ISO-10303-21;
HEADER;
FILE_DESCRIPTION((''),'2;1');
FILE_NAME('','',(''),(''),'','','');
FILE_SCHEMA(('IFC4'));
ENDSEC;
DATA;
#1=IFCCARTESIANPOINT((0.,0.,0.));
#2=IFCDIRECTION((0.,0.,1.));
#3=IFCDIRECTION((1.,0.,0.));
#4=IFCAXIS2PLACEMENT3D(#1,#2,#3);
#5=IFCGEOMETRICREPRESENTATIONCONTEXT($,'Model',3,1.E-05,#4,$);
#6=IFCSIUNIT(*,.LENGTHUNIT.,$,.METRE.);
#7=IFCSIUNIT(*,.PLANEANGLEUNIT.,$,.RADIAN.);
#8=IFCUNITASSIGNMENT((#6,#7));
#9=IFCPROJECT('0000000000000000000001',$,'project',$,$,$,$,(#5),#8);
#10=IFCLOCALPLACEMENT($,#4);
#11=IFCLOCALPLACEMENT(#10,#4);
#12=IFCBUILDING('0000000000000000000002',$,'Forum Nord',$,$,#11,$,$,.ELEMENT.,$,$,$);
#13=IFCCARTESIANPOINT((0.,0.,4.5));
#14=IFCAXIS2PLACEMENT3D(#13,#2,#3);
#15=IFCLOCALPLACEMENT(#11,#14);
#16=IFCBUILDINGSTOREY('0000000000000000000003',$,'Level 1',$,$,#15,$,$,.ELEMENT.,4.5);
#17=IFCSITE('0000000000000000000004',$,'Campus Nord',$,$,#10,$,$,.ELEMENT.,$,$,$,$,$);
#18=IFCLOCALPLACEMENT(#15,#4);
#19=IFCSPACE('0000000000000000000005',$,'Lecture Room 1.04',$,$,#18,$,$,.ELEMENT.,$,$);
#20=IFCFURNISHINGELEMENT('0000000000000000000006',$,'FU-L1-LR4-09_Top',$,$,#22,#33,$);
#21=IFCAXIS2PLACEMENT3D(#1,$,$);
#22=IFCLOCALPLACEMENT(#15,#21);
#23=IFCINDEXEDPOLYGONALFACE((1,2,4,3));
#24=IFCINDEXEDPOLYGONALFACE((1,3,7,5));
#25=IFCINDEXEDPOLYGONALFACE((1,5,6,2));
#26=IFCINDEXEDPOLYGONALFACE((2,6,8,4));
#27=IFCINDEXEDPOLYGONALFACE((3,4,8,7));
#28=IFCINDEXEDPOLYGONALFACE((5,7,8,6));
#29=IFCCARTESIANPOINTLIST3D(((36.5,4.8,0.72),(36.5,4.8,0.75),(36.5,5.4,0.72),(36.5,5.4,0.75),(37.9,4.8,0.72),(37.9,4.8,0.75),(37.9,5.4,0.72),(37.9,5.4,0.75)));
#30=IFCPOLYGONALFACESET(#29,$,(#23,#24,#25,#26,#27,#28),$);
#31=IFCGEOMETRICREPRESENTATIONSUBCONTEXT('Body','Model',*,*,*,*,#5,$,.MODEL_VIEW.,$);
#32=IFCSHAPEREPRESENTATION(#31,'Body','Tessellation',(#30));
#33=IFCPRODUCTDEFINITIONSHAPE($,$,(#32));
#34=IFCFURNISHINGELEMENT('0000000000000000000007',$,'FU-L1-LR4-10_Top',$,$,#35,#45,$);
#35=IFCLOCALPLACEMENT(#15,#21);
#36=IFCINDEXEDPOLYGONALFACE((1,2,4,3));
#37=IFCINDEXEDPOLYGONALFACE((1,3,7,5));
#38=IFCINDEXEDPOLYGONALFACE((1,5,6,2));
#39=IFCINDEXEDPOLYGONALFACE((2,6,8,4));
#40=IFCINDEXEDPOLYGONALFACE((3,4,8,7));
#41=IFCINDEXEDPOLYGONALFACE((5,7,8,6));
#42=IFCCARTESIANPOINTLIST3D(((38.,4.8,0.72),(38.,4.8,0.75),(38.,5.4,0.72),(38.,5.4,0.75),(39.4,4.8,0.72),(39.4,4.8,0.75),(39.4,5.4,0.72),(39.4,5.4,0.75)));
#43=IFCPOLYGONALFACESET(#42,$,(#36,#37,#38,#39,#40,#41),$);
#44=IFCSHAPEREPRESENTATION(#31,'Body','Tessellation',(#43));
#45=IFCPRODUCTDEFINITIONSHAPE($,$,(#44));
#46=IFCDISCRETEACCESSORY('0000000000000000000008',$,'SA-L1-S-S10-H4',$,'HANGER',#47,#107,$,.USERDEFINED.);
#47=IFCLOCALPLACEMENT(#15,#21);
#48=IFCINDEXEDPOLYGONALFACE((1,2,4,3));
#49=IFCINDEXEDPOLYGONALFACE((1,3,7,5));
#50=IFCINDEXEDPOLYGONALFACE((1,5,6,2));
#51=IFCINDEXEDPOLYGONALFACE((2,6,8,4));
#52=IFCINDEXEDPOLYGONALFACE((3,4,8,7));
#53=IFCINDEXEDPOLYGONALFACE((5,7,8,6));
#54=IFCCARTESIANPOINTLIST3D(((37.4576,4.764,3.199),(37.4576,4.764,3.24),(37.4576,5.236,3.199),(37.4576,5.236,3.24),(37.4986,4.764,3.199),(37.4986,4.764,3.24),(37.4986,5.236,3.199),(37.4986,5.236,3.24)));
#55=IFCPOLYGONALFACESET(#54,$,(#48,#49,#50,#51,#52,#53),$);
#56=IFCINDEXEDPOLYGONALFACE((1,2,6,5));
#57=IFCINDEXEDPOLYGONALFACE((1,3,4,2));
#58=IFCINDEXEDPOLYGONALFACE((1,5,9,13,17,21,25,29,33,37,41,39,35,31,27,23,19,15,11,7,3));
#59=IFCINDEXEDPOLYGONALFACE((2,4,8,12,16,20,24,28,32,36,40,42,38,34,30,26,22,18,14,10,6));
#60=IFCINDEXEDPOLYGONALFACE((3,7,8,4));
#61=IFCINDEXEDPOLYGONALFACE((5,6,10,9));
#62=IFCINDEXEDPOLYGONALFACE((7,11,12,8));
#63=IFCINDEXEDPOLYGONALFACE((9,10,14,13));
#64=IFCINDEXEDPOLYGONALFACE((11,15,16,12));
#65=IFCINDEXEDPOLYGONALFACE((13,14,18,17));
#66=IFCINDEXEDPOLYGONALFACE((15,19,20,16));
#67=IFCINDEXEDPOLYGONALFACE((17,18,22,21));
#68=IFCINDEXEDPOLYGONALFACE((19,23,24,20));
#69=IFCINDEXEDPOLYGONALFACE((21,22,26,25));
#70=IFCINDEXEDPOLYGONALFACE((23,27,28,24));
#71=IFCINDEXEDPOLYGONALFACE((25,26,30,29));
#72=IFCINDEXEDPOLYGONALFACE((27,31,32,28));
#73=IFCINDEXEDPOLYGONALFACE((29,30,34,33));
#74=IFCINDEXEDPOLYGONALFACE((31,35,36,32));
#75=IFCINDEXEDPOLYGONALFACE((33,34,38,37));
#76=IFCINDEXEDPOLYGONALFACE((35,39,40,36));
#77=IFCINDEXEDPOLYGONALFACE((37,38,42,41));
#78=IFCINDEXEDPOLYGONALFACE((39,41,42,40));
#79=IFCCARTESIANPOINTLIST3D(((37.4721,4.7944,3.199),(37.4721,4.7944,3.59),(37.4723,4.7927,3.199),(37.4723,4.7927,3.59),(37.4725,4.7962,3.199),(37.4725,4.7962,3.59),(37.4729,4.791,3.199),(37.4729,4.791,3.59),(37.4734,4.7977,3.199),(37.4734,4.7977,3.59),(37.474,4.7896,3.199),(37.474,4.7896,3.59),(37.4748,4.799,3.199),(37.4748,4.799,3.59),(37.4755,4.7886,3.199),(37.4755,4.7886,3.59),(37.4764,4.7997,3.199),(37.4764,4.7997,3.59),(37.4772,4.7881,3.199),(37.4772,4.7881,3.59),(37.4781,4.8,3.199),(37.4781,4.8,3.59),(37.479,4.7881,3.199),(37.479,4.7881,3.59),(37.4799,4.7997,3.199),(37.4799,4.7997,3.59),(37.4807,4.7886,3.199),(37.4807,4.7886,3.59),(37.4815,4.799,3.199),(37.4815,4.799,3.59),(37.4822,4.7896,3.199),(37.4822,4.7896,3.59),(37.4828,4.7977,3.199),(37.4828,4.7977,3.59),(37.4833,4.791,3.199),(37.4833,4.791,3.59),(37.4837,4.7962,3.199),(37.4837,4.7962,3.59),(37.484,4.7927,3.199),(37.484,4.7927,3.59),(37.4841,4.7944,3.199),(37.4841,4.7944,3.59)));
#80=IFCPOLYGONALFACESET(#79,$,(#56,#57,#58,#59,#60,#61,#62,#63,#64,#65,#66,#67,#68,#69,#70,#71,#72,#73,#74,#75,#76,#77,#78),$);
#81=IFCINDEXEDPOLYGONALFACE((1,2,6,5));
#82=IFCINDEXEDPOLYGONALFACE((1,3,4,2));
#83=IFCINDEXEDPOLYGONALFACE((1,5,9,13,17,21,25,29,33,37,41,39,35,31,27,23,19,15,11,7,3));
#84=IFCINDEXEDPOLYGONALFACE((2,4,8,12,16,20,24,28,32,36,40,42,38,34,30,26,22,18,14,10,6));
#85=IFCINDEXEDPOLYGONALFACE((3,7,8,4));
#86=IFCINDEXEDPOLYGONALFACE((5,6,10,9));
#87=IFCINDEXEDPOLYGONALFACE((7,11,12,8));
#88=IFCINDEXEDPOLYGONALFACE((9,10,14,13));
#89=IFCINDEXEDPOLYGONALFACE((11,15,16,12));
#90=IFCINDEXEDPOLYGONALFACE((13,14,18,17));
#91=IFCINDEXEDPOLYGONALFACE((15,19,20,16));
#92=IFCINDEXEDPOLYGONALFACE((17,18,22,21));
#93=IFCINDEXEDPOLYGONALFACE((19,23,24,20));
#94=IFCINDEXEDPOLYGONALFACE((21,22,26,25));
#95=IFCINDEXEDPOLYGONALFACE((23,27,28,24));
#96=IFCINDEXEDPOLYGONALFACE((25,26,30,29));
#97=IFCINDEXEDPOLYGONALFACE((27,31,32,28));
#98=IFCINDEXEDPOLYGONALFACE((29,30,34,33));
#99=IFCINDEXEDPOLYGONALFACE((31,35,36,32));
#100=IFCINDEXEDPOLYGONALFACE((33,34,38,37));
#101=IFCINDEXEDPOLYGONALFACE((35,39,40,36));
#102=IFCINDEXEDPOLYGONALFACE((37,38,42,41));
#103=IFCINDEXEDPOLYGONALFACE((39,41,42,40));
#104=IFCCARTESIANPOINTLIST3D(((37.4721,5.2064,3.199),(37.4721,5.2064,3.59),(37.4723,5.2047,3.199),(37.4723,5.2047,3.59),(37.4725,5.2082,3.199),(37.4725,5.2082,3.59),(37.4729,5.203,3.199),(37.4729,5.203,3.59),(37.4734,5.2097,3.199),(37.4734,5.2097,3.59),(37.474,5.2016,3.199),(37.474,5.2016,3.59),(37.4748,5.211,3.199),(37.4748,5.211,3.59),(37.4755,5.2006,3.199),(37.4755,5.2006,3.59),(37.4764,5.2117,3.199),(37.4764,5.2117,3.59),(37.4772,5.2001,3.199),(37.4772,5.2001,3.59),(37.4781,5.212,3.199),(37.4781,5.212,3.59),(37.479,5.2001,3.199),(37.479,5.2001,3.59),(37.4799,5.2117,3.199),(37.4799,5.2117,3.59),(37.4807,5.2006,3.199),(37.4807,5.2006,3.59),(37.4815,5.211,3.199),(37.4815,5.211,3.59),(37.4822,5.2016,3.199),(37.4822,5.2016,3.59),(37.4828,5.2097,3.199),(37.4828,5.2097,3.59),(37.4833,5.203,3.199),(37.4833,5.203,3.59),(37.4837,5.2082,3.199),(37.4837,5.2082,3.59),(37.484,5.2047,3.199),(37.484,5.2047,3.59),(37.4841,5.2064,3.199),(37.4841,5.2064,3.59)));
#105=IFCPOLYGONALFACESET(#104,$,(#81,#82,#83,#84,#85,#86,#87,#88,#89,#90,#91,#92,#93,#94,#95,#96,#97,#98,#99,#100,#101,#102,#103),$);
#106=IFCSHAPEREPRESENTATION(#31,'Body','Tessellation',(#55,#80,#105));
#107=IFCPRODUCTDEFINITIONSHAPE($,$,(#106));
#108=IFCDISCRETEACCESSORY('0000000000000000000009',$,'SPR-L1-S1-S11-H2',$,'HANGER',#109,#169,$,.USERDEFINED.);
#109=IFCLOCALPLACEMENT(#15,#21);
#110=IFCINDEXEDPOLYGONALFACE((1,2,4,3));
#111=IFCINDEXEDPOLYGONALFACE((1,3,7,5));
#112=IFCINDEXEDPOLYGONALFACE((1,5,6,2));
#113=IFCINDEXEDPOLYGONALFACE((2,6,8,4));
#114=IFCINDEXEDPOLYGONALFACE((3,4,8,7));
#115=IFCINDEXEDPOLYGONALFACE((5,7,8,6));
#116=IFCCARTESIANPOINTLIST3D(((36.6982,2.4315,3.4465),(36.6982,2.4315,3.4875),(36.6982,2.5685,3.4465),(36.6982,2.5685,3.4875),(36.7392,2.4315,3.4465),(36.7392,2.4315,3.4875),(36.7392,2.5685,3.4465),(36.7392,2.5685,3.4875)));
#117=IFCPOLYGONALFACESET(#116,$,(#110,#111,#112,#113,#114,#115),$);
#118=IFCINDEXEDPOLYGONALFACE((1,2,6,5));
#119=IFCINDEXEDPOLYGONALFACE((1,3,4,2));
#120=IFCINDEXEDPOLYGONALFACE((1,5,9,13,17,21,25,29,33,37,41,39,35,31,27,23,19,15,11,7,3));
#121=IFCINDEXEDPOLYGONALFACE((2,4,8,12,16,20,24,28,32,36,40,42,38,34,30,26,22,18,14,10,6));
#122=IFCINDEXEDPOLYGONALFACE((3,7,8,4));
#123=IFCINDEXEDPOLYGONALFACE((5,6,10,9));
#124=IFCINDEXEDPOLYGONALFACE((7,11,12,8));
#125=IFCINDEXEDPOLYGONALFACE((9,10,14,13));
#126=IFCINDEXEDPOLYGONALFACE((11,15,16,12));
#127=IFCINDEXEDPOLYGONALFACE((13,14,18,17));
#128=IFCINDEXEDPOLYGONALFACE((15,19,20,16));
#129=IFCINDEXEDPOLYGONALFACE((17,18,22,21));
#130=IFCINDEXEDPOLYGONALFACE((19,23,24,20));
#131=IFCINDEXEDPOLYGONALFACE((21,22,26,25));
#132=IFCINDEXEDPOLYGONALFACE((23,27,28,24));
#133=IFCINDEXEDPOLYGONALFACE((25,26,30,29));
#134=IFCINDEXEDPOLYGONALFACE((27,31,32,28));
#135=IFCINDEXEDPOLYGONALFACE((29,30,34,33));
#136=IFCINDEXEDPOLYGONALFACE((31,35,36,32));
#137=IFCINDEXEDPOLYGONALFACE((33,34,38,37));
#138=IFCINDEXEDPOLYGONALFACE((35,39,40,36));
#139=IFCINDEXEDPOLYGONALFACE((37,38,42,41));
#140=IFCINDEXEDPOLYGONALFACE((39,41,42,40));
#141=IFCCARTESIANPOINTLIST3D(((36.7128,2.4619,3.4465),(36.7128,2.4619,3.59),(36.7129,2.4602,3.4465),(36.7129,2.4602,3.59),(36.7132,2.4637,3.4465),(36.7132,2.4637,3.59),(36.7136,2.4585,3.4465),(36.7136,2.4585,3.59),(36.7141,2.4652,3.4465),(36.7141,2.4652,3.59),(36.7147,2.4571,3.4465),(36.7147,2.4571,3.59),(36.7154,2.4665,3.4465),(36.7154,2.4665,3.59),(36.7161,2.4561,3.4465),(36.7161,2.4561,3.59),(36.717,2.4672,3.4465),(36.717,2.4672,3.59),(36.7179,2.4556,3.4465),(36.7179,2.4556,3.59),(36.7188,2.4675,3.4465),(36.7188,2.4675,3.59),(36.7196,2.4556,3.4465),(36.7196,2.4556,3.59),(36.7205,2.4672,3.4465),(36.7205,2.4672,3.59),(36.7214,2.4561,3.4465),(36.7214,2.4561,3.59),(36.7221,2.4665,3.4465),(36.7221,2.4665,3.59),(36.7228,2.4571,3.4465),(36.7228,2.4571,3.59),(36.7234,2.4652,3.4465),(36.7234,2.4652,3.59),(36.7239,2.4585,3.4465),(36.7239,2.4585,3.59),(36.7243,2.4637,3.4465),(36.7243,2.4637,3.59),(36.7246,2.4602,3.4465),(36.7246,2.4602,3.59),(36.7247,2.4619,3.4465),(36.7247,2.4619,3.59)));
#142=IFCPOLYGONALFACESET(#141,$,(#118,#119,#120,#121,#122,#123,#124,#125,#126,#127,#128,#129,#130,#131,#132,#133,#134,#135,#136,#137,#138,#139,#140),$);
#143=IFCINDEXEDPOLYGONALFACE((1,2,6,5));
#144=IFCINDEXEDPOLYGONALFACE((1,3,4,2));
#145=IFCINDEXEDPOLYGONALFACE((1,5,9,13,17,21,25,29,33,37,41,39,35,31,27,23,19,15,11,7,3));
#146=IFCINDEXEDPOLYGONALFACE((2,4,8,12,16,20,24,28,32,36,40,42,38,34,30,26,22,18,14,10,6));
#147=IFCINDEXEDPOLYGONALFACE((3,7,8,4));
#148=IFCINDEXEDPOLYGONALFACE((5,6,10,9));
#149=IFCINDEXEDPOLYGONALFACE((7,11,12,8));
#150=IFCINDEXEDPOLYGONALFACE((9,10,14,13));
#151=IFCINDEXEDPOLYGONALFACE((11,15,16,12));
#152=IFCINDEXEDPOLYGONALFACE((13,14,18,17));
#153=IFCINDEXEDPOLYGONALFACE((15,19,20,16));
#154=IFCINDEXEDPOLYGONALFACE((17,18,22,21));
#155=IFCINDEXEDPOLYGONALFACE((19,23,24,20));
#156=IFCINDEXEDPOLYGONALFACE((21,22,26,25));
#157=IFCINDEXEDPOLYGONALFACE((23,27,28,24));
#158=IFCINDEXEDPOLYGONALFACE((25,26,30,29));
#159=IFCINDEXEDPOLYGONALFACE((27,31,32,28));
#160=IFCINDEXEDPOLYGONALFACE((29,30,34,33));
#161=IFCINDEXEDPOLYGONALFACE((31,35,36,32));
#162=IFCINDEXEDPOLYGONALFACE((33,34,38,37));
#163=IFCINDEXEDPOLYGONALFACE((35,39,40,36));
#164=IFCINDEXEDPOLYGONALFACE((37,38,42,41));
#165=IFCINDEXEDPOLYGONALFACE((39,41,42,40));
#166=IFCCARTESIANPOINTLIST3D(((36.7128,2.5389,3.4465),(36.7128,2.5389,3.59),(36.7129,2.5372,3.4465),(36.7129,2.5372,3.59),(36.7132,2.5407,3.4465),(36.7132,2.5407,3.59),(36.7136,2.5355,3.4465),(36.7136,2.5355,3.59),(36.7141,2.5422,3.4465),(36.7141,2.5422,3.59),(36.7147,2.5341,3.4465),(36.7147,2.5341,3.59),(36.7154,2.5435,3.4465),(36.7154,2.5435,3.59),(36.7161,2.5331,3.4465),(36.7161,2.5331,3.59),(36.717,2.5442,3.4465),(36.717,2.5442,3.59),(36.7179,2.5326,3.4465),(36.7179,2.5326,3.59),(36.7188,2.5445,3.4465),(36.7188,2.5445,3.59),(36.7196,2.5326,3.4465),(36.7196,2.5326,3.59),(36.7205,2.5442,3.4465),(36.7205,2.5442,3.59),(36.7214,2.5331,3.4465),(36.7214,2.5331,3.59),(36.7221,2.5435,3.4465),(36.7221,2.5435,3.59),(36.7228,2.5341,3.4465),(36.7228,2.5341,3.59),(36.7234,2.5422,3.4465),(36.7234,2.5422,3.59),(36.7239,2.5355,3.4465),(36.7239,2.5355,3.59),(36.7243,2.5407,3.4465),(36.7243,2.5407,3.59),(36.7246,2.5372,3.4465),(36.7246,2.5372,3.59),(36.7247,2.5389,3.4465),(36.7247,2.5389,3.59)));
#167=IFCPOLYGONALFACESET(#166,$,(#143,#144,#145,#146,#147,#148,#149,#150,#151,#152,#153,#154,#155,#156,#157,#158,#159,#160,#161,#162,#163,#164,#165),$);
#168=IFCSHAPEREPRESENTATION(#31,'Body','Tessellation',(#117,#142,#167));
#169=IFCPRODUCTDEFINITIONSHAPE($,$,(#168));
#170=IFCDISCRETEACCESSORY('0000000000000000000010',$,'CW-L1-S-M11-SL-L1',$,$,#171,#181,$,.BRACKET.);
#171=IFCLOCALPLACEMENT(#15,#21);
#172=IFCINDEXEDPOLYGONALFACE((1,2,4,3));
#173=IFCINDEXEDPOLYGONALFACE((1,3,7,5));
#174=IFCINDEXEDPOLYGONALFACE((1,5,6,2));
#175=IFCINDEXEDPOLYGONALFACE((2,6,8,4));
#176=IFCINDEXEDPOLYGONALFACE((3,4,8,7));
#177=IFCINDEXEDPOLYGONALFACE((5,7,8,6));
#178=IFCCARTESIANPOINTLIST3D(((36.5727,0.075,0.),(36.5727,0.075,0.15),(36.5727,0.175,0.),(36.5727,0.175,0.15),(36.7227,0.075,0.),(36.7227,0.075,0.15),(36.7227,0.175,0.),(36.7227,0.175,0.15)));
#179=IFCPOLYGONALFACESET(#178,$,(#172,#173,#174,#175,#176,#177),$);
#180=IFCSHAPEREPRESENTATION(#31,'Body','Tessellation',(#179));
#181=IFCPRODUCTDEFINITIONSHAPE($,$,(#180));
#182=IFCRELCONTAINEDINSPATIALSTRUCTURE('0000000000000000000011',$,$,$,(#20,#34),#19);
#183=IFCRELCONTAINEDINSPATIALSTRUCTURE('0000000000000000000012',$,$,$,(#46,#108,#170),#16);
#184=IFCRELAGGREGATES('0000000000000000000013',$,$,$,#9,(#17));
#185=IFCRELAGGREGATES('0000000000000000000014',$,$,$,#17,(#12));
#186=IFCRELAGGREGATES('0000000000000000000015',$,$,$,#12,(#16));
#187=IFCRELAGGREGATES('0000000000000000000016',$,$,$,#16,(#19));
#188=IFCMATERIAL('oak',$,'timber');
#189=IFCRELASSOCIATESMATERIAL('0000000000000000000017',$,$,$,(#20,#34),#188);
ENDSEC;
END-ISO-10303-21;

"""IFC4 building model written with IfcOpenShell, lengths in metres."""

from ifc_helpers import new_model, si_unit, frame, frame_2d, origin_with_axes, origin_2d_with_axis, place, context, subcontext, project, spatial, rectangle, circle, extrude, material, element, save


model = new_model("IFC4")

# Units and contexts
model_context = context("Model", 3, precision=1e-05, world=origin_with_axes())
body_context = subcontext(model_context, "Body", "Model", "MODEL_VIEW")
ifc_project = project(units=[si_unit("LENGTHUNIT", "METRE"), si_unit("PLANEANGLEUNIT", "RADIAN")], contexts=[model_context])

# Site, building, storey
site_placement = place(None, origin_with_axes())
site = spatial("IfcSite", under=ifc_project, at=site_placement, Name="Campus Nord", CompositionType="ELEMENT")
building_placement = place(site_placement, origin_with_axes())
building = spatial("IfcBuilding", under=site, at=building_placement, Name="Forum Nord", CompositionType="ELEMENT")
storey_placement = place(building_placement, frame((0.0, 0.0, 4.5), z_axis=(0.0, 0.0, 1.0), x_axis=(1.0, 0.0, 0.0)))
storey = spatial("IfcBuildingStorey", under=building, at=storey_placement, Name="Level 1", CompositionType="ELEMENT", Elevation=4.5)

# Shared definitions
space_placement = place(storey_placement, origin_with_axes())
space = spatial("IfcSpace", under=storey, at=space_placement, Name="Lecture Room 1.04", CompositionType="ELEMENT")

# Furnishing elements
ifc_material_1 = material(Name="oak", Category="timber")
furnishing_1_placement = place(storey_placement, frame((36.5, 4.8, 0.0), z_axis=(0.0, 0.0, 1.0), x_axis=(1.0, 0.0, 0.0)))
element("IfcFurnishingElement", 1, at=furnishing_1_placement, inside=space, material=ifc_material_1, Name="FU-L1-LR4-09_Top", context=body_context, shape_type="SweptSolid", body=[
    extrude(rectangle(XDim=1.4, YDim=0.6, at=frame_2d((0.7, 0.3), x_axis=(1.0, 0.0))), frame((0.0, 0.0, 0.72), z_axis=(0.0, 0.0, 1.0), x_axis=(1.0, 0.0, 0.0)), (0.0, 0.0, 1.0), 0.03),
])
furnishing_2_placement = place(storey_placement, frame((38.0, 4.8, 0.0), z_axis=(0.0, 0.0, 1.0), x_axis=(1.0, 0.0, 0.0)))
element("IfcFurnishingElement", 2, at=furnishing_2_placement, inside=space, material=ifc_material_1, Name="FU-L1-LR4-10_Top", context=body_context, shape_type="SweptSolid", body=[
    extrude(rectangle(XDim=1.4, YDim=0.6, at=frame_2d((0.7, 0.3), x_axis=(1.0, 0.0))), frame((0.0, 0.0, 0.72), z_axis=(0.0, 0.0, 1.0), x_axis=(1.0, 0.0, 0.0)), (0.0, 0.0, 1.0), 0.03),
])

# Discrete accessories
discrete_accessory_1_placement = place(storey_placement, frame((37.4781, 5.0, 3.24), z_axis=(0.0, 0.0, 1.0), x_axis=(0.0, 1.0, 0.0)))
element("IfcDiscreteAccessory", 3, at=discrete_accessory_1_placement, inside=storey, Name="SA-L1-S-S10-H4", ObjectType="HANGER", PredefinedType="USERDEFINED", context=body_context, shape_type="SweptSolid", body=[
    extrude(rectangle(XDim=0.472, YDim=0.041, at=origin_2d_with_axis()), frame((0.0, 0.0, -0.041), z_axis=(0.0, 0.0, 1.0), x_axis=(1.0, 0.0, 0.0)), (0.0, 0.0, 1.0), 0.041),
    extrude(circle(Radius=0.006, at=frame_2d((-0.206, 0.0), x_axis=(1.0, 0.0))), frame((0.0, 0.0, -0.041), z_axis=(0.0, 0.0, 1.0), x_axis=(1.0, 0.0, 0.0)), (0.0, 0.0, 1.0), 0.391),
    extrude(circle(Radius=0.006, at=frame_2d((0.206, 0.0), x_axis=(1.0, 0.0))), frame((0.0, 0.0, -0.041), z_axis=(0.0, 0.0, 1.0), x_axis=(1.0, 0.0, 0.0)), (0.0, 0.0, 1.0), 0.391),
])
discrete_accessory_2_placement = place(storey_placement, frame((36.7188, 2.5, 3.4875), z_axis=(0.0, 0.0, 1.0), x_axis=(0.0, 1.0, 0.0)))
element("IfcDiscreteAccessory", 4, at=discrete_accessory_2_placement, inside=storey, Name="SPR-L1-S1-S11-H2", ObjectType="HANGER", PredefinedType="USERDEFINED", context=body_context, shape_type="SweptSolid", body=[
    extrude(rectangle(XDim=0.137, YDim=0.041, at=origin_2d_with_axis()), frame((0.0, 0.0, -0.041), z_axis=(0.0, 0.0, 1.0), x_axis=(1.0, 0.0, 0.0)), (0.0, 0.0, 1.0), 0.041),
    extrude(circle(Radius=0.006, at=frame_2d((-0.0385, 0.0), x_axis=(1.0, 0.0))), frame((0.0, 0.0, -0.041), z_axis=(0.0, 0.0, 1.0), x_axis=(1.0, 0.0, 0.0)), (0.0, 0.0, 1.0), 0.1435),
    extrude(circle(Radius=0.006, at=frame_2d((0.0385, 0.0), x_axis=(1.0, 0.0))), frame((0.0, 0.0, -0.041), z_axis=(0.0, 0.0, 1.0), x_axis=(1.0, 0.0, 0.0)), (0.0, 0.0, 1.0), 0.1435),
])
discrete_accessory_3_placement = place(storey_placement, frame((36.6477, 0.125, 0.0), z_axis=(0.0, 0.0, 1.0), x_axis=(1.0, 0.0, 0.0)))
element("IfcDiscreteAccessory", 5, at=discrete_accessory_3_placement, inside=storey, Name="CW-L1-S-M11-SL-L1", PredefinedType="BRACKET", context=body_context, shape_type="SweptSolid", body=[
    extrude(rectangle(XDim=0.15, YDim=0.1, at=origin_2d_with_axis()), origin_with_axes(), (0.0, 0.0, 1.0), 0.15),
])

save(model, "model.ifc")
